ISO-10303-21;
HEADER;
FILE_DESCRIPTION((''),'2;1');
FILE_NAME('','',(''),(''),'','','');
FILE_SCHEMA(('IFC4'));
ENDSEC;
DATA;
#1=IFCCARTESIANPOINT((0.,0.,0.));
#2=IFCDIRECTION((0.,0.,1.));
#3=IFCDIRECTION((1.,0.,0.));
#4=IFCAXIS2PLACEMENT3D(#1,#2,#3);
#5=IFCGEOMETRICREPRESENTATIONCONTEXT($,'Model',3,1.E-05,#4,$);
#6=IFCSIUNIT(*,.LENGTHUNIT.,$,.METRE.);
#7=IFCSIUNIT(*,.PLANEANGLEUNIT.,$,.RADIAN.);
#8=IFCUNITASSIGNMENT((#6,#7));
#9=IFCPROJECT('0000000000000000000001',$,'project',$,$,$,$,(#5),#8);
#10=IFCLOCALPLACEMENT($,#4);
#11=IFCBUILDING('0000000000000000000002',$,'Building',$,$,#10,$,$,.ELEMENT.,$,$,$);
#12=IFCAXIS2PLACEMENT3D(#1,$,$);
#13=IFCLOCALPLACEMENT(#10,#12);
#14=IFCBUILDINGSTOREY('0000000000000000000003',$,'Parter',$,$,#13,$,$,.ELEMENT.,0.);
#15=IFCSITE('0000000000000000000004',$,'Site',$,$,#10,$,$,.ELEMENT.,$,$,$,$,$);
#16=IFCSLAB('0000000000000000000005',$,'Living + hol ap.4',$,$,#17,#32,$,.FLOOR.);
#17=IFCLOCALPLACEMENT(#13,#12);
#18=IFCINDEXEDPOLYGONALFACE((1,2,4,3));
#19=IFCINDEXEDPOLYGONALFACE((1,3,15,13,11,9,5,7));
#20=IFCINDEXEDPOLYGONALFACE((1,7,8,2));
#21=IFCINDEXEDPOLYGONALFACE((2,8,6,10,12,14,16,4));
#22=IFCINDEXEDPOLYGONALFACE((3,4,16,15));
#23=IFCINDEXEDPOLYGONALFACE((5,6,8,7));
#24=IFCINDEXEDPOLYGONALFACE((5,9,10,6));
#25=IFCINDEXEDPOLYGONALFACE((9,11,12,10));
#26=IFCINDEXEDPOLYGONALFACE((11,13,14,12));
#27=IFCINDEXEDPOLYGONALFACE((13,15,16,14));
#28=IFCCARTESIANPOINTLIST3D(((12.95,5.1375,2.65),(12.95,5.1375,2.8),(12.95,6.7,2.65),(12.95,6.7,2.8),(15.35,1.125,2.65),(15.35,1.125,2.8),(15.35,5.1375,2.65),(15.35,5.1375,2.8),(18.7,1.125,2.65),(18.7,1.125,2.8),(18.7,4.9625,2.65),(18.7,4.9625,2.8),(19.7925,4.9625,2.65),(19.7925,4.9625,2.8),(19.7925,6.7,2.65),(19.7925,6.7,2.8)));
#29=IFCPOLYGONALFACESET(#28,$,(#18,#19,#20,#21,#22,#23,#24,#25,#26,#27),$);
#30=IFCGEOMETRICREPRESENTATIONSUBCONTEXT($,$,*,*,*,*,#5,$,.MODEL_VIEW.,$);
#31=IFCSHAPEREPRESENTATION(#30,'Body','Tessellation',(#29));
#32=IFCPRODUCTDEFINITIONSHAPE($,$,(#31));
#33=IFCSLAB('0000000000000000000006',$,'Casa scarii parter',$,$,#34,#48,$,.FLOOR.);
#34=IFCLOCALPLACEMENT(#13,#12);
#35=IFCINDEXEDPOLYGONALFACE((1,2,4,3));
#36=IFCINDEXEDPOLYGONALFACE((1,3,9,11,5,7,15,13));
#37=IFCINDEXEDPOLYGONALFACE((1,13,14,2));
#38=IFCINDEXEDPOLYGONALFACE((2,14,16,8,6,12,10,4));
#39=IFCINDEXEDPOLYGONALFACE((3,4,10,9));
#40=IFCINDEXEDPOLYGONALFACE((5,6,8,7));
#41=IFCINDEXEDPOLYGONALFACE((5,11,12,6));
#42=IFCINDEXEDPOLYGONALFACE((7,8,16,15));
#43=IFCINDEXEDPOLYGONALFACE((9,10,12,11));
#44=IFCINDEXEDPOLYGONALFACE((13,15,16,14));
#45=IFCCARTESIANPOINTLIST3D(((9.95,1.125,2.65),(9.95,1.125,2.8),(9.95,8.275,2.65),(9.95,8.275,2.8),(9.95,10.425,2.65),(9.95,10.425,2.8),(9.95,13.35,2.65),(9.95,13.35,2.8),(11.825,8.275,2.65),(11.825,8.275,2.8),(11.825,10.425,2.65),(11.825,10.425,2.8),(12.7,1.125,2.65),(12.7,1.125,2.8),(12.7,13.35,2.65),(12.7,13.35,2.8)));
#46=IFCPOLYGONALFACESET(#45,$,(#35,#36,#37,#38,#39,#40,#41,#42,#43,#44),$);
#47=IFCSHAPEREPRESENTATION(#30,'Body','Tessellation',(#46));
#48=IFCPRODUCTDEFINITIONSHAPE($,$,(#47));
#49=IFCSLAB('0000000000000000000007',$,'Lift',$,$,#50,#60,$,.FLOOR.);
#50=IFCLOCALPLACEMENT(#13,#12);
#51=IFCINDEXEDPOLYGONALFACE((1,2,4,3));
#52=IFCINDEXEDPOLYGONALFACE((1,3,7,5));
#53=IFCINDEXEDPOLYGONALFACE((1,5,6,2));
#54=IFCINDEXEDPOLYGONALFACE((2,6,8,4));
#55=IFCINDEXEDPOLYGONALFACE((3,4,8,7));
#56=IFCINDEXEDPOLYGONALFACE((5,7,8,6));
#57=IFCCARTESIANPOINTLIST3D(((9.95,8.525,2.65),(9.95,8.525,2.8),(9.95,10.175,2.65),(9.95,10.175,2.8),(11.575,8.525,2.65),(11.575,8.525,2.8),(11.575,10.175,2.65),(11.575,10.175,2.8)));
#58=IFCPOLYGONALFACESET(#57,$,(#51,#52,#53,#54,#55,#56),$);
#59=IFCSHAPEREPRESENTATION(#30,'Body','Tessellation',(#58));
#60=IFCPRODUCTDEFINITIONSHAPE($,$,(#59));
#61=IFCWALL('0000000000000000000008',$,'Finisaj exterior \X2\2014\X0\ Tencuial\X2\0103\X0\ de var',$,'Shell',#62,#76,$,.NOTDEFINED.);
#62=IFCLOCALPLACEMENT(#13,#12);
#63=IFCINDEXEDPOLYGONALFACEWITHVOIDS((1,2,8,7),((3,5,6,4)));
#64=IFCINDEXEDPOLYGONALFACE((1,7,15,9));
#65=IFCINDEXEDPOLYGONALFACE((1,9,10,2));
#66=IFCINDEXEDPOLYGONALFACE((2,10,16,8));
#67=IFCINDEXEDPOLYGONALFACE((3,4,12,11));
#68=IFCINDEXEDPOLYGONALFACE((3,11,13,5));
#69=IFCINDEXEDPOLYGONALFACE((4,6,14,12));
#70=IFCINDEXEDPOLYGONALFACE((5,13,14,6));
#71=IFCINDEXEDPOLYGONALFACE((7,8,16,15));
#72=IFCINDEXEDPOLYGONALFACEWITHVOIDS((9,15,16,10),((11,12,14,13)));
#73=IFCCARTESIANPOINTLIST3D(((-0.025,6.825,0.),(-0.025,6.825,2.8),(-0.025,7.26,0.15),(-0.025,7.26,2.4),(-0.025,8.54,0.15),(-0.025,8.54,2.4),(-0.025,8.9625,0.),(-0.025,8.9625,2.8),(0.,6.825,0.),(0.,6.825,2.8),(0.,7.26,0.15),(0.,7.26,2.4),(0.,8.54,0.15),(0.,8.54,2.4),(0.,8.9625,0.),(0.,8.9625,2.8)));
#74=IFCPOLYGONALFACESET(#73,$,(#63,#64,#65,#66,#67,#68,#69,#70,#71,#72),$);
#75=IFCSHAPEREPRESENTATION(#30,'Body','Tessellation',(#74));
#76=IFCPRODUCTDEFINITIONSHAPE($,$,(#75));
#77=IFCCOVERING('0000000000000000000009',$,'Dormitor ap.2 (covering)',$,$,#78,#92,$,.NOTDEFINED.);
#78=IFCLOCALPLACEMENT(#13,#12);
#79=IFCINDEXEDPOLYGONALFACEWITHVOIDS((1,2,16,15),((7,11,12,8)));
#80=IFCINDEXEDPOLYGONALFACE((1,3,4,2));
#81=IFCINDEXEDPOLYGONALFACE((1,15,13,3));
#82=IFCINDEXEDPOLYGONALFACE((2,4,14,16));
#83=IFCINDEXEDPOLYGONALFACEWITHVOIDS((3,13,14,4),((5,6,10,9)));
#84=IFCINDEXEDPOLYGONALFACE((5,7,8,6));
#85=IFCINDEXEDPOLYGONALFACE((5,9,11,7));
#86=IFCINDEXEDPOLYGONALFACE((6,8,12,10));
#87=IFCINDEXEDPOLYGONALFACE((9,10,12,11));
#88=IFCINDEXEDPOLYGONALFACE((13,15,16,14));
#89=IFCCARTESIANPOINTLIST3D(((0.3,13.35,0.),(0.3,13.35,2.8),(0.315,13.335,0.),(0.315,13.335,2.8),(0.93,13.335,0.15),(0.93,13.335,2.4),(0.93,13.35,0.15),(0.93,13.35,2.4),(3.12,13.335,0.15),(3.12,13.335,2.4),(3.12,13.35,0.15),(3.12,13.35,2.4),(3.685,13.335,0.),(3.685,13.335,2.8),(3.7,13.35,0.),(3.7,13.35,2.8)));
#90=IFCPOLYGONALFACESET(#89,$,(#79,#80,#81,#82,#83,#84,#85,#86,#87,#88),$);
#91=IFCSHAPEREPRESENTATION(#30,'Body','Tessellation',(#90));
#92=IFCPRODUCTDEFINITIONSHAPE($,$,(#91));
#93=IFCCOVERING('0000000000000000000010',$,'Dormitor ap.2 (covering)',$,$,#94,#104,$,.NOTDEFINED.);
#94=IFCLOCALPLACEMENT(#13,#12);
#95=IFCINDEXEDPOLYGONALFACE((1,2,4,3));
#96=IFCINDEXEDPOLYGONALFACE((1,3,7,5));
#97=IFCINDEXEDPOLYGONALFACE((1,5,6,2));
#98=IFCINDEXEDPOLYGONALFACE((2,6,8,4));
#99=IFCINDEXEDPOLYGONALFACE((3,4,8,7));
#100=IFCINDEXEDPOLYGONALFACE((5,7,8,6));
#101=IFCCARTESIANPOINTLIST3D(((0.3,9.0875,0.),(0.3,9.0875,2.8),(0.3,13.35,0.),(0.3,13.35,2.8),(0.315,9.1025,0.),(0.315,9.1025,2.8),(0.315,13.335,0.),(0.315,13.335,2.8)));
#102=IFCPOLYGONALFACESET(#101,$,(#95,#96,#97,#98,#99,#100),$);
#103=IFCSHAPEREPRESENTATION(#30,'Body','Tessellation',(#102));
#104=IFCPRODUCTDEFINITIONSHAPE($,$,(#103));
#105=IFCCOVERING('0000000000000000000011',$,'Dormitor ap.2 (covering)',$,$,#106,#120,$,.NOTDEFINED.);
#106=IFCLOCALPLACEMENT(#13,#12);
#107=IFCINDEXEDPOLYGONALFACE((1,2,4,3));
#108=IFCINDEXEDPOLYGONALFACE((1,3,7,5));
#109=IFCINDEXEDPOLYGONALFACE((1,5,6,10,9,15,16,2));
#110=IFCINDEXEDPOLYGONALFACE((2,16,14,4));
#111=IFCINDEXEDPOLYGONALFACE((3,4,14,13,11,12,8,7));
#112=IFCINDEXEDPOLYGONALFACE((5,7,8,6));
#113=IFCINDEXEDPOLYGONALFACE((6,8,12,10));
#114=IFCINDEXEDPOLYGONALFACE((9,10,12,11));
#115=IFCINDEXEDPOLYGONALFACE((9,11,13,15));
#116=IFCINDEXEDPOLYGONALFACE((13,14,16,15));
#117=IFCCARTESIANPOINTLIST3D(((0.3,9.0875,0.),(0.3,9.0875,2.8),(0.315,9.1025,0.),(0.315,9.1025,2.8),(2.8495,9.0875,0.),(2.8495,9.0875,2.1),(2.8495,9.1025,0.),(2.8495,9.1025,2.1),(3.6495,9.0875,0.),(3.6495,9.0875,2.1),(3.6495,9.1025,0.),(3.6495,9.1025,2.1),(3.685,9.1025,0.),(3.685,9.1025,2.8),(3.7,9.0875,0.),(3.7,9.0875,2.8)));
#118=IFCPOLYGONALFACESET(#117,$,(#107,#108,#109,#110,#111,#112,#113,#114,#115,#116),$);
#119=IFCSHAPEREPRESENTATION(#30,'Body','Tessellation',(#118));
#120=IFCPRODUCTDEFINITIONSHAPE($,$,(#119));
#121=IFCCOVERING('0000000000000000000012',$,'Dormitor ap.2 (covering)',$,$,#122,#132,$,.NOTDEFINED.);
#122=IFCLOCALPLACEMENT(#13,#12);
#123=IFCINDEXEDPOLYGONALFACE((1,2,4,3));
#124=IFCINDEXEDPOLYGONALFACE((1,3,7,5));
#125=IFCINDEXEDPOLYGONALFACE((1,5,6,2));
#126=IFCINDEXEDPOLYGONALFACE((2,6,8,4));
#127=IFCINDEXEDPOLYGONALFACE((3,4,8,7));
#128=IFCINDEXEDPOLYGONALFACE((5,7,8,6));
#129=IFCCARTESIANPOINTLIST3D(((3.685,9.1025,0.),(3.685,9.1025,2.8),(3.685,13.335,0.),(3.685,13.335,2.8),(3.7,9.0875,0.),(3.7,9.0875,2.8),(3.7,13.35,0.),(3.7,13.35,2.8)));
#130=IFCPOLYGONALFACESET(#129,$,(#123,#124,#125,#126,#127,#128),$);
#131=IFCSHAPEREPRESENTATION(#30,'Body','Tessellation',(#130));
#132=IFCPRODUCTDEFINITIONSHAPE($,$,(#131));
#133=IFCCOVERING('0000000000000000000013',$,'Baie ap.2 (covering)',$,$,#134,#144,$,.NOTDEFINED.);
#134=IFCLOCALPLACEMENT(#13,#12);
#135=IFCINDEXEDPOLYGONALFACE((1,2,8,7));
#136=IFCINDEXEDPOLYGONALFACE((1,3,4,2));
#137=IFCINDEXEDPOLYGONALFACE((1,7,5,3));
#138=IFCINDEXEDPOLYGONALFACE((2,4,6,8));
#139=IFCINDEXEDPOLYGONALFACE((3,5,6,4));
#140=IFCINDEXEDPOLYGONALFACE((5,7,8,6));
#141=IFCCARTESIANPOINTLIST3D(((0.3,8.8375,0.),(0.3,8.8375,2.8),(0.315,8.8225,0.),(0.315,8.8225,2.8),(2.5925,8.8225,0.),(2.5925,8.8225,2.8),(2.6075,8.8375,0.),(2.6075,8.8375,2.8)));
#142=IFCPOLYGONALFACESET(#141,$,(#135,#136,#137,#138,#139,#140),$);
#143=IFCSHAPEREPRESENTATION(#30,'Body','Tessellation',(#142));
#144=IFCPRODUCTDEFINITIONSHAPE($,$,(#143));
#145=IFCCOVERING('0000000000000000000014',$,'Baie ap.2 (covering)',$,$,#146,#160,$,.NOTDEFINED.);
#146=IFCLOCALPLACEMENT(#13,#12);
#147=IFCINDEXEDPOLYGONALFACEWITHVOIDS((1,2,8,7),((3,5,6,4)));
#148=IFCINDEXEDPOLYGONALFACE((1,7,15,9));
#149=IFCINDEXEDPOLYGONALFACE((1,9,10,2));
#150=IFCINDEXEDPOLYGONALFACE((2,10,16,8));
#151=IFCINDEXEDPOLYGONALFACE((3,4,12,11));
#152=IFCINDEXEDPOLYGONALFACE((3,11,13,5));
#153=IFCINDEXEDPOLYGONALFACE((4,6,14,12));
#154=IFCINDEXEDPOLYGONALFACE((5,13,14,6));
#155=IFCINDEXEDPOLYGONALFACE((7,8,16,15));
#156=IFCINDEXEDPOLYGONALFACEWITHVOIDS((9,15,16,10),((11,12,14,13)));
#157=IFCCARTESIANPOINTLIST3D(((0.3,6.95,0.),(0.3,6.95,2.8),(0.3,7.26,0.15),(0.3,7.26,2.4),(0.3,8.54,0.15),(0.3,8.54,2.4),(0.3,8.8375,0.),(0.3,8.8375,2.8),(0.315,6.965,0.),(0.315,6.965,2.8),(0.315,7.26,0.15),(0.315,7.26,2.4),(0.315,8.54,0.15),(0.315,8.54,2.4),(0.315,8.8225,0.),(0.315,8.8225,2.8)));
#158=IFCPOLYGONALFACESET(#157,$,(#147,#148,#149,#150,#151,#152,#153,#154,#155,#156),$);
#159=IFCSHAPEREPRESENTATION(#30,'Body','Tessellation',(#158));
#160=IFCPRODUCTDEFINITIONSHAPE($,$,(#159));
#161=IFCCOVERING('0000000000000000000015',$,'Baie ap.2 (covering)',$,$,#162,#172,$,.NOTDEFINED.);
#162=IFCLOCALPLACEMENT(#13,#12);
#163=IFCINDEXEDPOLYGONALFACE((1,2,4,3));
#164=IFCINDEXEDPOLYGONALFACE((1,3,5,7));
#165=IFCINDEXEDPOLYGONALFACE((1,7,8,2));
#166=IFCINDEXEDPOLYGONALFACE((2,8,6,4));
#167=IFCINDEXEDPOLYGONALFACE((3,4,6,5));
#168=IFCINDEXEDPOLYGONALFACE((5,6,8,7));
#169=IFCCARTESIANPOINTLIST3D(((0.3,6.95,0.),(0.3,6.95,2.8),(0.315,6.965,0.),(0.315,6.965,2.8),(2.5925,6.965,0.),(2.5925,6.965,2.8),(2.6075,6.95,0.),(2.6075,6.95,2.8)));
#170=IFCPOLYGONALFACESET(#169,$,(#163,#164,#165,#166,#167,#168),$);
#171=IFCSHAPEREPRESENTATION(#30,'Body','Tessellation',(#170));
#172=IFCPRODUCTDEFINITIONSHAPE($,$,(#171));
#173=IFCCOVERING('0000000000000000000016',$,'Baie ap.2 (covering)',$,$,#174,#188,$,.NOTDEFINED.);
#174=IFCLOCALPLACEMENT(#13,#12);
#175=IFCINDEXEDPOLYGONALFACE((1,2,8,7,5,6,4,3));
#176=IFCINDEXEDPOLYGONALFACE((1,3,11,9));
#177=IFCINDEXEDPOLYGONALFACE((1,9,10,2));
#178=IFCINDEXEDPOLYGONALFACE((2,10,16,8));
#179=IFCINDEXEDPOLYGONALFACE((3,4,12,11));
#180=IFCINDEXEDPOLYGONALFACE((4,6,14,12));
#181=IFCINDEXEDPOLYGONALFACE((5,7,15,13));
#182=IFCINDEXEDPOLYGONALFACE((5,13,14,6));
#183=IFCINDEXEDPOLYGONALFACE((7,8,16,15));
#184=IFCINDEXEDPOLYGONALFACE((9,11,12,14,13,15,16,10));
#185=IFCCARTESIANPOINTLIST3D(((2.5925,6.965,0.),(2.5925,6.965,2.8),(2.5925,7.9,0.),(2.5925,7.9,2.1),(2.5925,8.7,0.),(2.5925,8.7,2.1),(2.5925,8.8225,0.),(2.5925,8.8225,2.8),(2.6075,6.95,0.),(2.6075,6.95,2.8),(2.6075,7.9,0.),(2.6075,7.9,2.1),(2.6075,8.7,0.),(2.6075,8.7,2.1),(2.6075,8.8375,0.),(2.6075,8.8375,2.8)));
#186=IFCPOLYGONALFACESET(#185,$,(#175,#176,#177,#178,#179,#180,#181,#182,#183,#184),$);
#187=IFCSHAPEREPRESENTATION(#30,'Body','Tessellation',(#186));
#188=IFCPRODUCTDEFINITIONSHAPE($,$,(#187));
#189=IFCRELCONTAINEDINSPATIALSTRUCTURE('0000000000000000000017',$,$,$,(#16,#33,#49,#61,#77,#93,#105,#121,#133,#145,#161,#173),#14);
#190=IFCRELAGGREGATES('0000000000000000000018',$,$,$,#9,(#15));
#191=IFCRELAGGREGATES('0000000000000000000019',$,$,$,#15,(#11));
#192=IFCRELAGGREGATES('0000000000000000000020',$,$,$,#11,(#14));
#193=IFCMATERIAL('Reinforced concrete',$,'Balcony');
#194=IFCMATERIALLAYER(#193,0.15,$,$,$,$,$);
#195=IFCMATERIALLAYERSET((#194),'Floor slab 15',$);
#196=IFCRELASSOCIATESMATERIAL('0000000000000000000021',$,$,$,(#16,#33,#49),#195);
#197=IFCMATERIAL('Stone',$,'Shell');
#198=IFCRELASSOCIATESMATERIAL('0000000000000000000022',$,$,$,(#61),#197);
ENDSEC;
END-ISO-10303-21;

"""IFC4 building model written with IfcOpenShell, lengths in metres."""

from ifc_helpers import new_model, si_unit, frame, origin, origin_with_axes, origin_2d, place, context, subcontext, project, spatial, polyline, rectangle, outline, extrude, material, layer, layer_set, layer_usage, element, save


model = new_model("IFC4")

# Units and contexts
model_context = context("Model", 3, precision=1e-05, world=origin_with_axes())
sub_context = subcontext(model_context, None, None, "MODEL_VIEW")
ifc_project = project(units=[si_unit("LENGTHUNIT", "METRE"), si_unit("PLANEANGLEUNIT", "RADIAN")], contexts=[model_context])

# Site, building, storey
placement = place(None, origin_with_axes())
site = spatial("IfcSite", under=ifc_project, at=placement, Name="Site", CompositionType="ELEMENT")
building = spatial("IfcBuilding", under=site, at=placement, Name="Building", CompositionType="ELEMENT")
storey_placement = place(placement, origin())
storey = spatial("IfcBuildingStorey", under=building, at=storey_placement, Name="Parter", CompositionType="ELEMENT", Elevation=0.0)

# Slabs
ifc_material_1 = material(Name="Reinforced concrete", Category="Balcony")
ifc_layer = layer(ifc_material_1, 0.15)
ifc_layer_set = layer_set([ifc_layer], Name="Floor slab 15")
ifc_layer_usage = layer_usage(ifc_layer_set, "AXIS3", "POSITIVE", 0.0)
slab_1_placement = place(storey_placement, frame((0.0, 0.0, 2.65)))
element("IfcSlab", 1, at=slab_1_placement, inside=storey, material=ifc_layer_usage, Name="Living + hol ap.4", PredefinedType="FLOOR", context=sub_context, shape_type="SweptSolid", body=[
    extrude(outline(polyline([(18.7, 4.9625), (19.7925, 4.9625), (19.7925, 6.7), (12.95, 6.7), (12.95, 5.1375), (15.35, 5.1375), (15.35, 1.125), (18.7, 1.125), (18.7, 4.9625)])), origin(), (0.0, 0.0, 1.0), 0.15),
])
slab_2_placement = place(storey_placement, frame((0.0, 0.0, 2.65)))
element("IfcSlab", 2, at=slab_2_placement, inside=storey, material=ifc_layer_usage, Name="Casa scarii parter", PredefinedType="FLOOR", context=sub_context, shape_type="SweptSolid", body=[
    extrude(outline(polyline([(9.95, 13.35), (9.95, 10.425), (11.825, 10.425), (11.825, 8.275), (9.95, 8.275), (9.95, 1.125), (12.7, 1.125), (12.7, 13.35), (9.95, 13.35)])), origin(), (0.0, 0.0, 1.0), 0.15),
])
slab_3_placement = place(storey_placement, frame((0.0, 0.0, 2.65)))
element("IfcSlab", 3, at=slab_3_placement, inside=storey, material=ifc_layer_usage, Name="Lift", PredefinedType="FLOOR", context=sub_context, shape_type="SweptSolid", body=[
    extrude(outline(polyline([(11.575, 10.175), (9.95, 10.175), (9.95, 8.525), (11.575, 8.525), (11.575, 10.175)])), origin(), (0.0, 0.0, 1.0), 0.15),
])

# Wall, opening
ifc_material_2 = material(Name="Stone", Category="Shell")
wall_placement = place(storey_placement, origin_with_axes())
wall = element("IfcWall", 4, at=wall_placement, inside=storey, material=ifc_material_2, Name="Finisaj exterior — Tencuială de var", ObjectType="Shell", PredefinedType="NOTDEFINED", context=sub_context, shape_type="SweptSolid", body=[
    extrude(outline(polyline([(-0.025, 8.9625), (-0.025, 6.825), (0.0, 6.825), (0.0, 8.9625), (-0.025, 8.9625)])), origin(), (0.0, 0.0, 1.0), 2.8),
])
opening_1_placement = place(wall_placement, frame((-0.075, 7.9, 0.15), z_axis=(1.0, 0.0, 0.0), x_axis=(0.0, 1.0, 0.0)))
element("IfcOpeningElement", 5, at=opening_1_placement, cuts=wall, PredefinedType="OPENING", context=sub_context, shape_type="SweptSolid", body=[
    extrude(rectangle(XDim=1.28, YDim=2.25, at=origin_2d()), frame((0.0, 1.125, 0.0)), (0.0, 0.0, 1.0), 0.5),
])

# Covering, opening
covering_1_placement = place(storey_placement, origin_with_axes())
covering_1 = element("IfcCovering", 6, at=covering_1_placement, inside=storey, Name="Dormitor ap.2 (covering)", PredefinedType="NOTDEFINED", context=sub_context, shape_type="SweptSolid", body=[
    extrude(outline(polyline([(3.7, 13.35), (0.3, 13.35), (0.315, 13.335), (3.685, 13.335), (3.7, 13.35)])), origin(), (0.0, 0.0, 1.0), 2.8),
])
opening_2_placement = place(covering_1_placement, frame((2.025, 13.665, 0.15), z_axis=(0.0, -1.0, 0.0), x_axis=(1.0, 0.0, 0.0)))
element("IfcOpeningElement", 7, at=opening_2_placement, cuts=covering_1, PredefinedType="OPENING", context=sub_context, shape_type="SweptSolid", body=[
    extrude(rectangle(XDim=2.19, YDim=2.25, at=origin_2d()), frame((0.0, 1.125, 0.0)), (0.0, 0.0, 1.0), 0.38),
])

# Covering
covering_2_placement = place(storey_placement, origin_with_axes())
element("IfcCovering", 8, at=covering_2_placement, inside=storey, Name="Dormitor ap.2 (covering)", PredefinedType="NOTDEFINED", context=sub_context, shape_type="SweptSolid", body=[
    extrude(outline(polyline([(0.3, 13.35), (0.3, 9.0875), (0.315, 9.1025), (0.315, 13.335), (0.3, 13.35)])), origin(), (0.0, 0.0, 1.0), 2.8),
])

# Covering, opening
covering_3_placement = place(storey_placement, origin_with_axes())
covering_3 = element("IfcCovering", 9, at=covering_3_placement, inside=storey, Name="Dormitor ap.2 (covering)", PredefinedType="NOTDEFINED", context=sub_context, shape_type="SweptSolid", body=[
    extrude(outline(polyline([(0.3, 9.0875), (3.7, 9.0875), (3.685, 9.1025), (0.315, 9.1025), (0.3, 9.0875)])), origin(), (0.0, 0.0, 1.0), 2.8),
])
opening_3_placement = place(covering_3_placement, frame((3.2495, 9.1525, 0.0), z_axis=(0.0, -1.0, 0.0), x_axis=(1.0, 0.0, 0.0)))
element("IfcOpeningElement", 10, at=opening_3_placement, cuts=covering_3, PredefinedType="OPENING", context=sub_context, shape_type="SweptSolid", body=[
    extrude(rectangle(XDim=0.8, YDim=2.1, at=origin_2d()), frame((0.0, 1.05, 0.0)), (0.0, 0.0, 1.0), 0.38),
])

# Coverings
covering_4_placement = place(storey_placement, origin_with_axes())
element("IfcCovering", 11, at=covering_4_placement, inside=storey, Name="Dormitor ap.2 (covering)", PredefinedType="NOTDEFINED", context=sub_context, shape_type="SweptSolid", body=[
    extrude(outline(polyline([(3.7, 9.0875), (3.7, 13.35), (3.685, 13.335), (3.685, 9.1025), (3.7, 9.0875)])), origin(), (0.0, 0.0, 1.0), 2.8),
])
covering_5_placement = place(storey_placement, origin_with_axes())
element("IfcCovering", 12, at=covering_5_placement, inside=storey, Name="Baie ap.2 (covering)", PredefinedType="NOTDEFINED", context=sub_context, shape_type="SweptSolid", body=[
    extrude(outline(polyline([(2.6075, 8.8375), (0.3, 8.8375), (0.315, 8.8225), (2.5925, 8.8225), (2.6075, 8.8375)])), origin(), (0.0, 0.0, 1.0), 2.8),
])

# Covering, opening
covering_6_placement = place(storey_placement, origin_with_axes())
covering_6 = element("IfcCovering", 13, at=covering_6_placement, inside=storey, Name="Baie ap.2 (covering)", PredefinedType="NOTDEFINED", context=sub_context, shape_type="SweptSolid", body=[
    extrude(outline(polyline([(0.3, 8.8375), (0.3, 6.95), (0.315, 6.965), (0.315, 8.8225), (0.3, 8.8375)])), origin(), (0.0, 0.0, 1.0), 2.8),
])
opening_4_placement = place(covering_6_placement, frame((-0.015, 7.9, 0.15), z_axis=(1.0, 0.0, 0.0), x_axis=(0.0, 1.0, 0.0)))
element("IfcOpeningElement", 14, at=opening_4_placement, cuts=covering_6, PredefinedType="OPENING", context=sub_context, shape_type="SweptSolid", body=[
    extrude(rectangle(XDim=1.28, YDim=2.25, at=origin_2d()), frame((0.0, 1.125, 0.0)), (0.0, 0.0, 1.0), 0.38),
])

# Covering
covering_7_placement = place(storey_placement, origin_with_axes())
element("IfcCovering", 15, at=covering_7_placement, inside=storey, Name="Baie ap.2 (covering)", PredefinedType="NOTDEFINED", context=sub_context, shape_type="SweptSolid", body=[
    extrude(outline(polyline([(0.3, 6.95), (2.6075, 6.95), (2.5925, 6.965), (0.315, 6.965), (0.3, 6.95)])), origin(), (0.0, 0.0, 1.0), 2.8),
])

# Covering, opening
covering_8_placement = place(storey_placement, origin_with_axes())
covering_8 = element("IfcCovering", 16, at=covering_8_placement, inside=storey, Name="Baie ap.2 (covering)", PredefinedType="NOTDEFINED", context=sub_context, shape_type="SweptSolid", body=[
    extrude(outline(polyline([(2.6075, 6.95), (2.6075, 8.8375), (2.5925, 8.8225), (2.5925, 6.965), (2.6075, 6.95)])), origin(), (0.0, 0.0, 1.0), 2.8),
])
opening_5_placement = place(covering_8_placement, frame((2.5425, 8.3, 0.0), z_axis=(1.0, 0.0, 0.0), x_axis=(0.0, 1.0, 0.0)))
element("IfcOpeningElement", 17, at=opening_5_placement, cuts=covering_8, PredefinedType="OPENING", context=sub_context, shape_type="SweptSolid", body=[
    extrude(rectangle(XDim=0.8, YDim=2.1, at=origin_2d()), frame((0.0, 1.05, 0.0)), (0.0, 0.0, 1.0), 0.38),
])

save(model, "model.ifc")
